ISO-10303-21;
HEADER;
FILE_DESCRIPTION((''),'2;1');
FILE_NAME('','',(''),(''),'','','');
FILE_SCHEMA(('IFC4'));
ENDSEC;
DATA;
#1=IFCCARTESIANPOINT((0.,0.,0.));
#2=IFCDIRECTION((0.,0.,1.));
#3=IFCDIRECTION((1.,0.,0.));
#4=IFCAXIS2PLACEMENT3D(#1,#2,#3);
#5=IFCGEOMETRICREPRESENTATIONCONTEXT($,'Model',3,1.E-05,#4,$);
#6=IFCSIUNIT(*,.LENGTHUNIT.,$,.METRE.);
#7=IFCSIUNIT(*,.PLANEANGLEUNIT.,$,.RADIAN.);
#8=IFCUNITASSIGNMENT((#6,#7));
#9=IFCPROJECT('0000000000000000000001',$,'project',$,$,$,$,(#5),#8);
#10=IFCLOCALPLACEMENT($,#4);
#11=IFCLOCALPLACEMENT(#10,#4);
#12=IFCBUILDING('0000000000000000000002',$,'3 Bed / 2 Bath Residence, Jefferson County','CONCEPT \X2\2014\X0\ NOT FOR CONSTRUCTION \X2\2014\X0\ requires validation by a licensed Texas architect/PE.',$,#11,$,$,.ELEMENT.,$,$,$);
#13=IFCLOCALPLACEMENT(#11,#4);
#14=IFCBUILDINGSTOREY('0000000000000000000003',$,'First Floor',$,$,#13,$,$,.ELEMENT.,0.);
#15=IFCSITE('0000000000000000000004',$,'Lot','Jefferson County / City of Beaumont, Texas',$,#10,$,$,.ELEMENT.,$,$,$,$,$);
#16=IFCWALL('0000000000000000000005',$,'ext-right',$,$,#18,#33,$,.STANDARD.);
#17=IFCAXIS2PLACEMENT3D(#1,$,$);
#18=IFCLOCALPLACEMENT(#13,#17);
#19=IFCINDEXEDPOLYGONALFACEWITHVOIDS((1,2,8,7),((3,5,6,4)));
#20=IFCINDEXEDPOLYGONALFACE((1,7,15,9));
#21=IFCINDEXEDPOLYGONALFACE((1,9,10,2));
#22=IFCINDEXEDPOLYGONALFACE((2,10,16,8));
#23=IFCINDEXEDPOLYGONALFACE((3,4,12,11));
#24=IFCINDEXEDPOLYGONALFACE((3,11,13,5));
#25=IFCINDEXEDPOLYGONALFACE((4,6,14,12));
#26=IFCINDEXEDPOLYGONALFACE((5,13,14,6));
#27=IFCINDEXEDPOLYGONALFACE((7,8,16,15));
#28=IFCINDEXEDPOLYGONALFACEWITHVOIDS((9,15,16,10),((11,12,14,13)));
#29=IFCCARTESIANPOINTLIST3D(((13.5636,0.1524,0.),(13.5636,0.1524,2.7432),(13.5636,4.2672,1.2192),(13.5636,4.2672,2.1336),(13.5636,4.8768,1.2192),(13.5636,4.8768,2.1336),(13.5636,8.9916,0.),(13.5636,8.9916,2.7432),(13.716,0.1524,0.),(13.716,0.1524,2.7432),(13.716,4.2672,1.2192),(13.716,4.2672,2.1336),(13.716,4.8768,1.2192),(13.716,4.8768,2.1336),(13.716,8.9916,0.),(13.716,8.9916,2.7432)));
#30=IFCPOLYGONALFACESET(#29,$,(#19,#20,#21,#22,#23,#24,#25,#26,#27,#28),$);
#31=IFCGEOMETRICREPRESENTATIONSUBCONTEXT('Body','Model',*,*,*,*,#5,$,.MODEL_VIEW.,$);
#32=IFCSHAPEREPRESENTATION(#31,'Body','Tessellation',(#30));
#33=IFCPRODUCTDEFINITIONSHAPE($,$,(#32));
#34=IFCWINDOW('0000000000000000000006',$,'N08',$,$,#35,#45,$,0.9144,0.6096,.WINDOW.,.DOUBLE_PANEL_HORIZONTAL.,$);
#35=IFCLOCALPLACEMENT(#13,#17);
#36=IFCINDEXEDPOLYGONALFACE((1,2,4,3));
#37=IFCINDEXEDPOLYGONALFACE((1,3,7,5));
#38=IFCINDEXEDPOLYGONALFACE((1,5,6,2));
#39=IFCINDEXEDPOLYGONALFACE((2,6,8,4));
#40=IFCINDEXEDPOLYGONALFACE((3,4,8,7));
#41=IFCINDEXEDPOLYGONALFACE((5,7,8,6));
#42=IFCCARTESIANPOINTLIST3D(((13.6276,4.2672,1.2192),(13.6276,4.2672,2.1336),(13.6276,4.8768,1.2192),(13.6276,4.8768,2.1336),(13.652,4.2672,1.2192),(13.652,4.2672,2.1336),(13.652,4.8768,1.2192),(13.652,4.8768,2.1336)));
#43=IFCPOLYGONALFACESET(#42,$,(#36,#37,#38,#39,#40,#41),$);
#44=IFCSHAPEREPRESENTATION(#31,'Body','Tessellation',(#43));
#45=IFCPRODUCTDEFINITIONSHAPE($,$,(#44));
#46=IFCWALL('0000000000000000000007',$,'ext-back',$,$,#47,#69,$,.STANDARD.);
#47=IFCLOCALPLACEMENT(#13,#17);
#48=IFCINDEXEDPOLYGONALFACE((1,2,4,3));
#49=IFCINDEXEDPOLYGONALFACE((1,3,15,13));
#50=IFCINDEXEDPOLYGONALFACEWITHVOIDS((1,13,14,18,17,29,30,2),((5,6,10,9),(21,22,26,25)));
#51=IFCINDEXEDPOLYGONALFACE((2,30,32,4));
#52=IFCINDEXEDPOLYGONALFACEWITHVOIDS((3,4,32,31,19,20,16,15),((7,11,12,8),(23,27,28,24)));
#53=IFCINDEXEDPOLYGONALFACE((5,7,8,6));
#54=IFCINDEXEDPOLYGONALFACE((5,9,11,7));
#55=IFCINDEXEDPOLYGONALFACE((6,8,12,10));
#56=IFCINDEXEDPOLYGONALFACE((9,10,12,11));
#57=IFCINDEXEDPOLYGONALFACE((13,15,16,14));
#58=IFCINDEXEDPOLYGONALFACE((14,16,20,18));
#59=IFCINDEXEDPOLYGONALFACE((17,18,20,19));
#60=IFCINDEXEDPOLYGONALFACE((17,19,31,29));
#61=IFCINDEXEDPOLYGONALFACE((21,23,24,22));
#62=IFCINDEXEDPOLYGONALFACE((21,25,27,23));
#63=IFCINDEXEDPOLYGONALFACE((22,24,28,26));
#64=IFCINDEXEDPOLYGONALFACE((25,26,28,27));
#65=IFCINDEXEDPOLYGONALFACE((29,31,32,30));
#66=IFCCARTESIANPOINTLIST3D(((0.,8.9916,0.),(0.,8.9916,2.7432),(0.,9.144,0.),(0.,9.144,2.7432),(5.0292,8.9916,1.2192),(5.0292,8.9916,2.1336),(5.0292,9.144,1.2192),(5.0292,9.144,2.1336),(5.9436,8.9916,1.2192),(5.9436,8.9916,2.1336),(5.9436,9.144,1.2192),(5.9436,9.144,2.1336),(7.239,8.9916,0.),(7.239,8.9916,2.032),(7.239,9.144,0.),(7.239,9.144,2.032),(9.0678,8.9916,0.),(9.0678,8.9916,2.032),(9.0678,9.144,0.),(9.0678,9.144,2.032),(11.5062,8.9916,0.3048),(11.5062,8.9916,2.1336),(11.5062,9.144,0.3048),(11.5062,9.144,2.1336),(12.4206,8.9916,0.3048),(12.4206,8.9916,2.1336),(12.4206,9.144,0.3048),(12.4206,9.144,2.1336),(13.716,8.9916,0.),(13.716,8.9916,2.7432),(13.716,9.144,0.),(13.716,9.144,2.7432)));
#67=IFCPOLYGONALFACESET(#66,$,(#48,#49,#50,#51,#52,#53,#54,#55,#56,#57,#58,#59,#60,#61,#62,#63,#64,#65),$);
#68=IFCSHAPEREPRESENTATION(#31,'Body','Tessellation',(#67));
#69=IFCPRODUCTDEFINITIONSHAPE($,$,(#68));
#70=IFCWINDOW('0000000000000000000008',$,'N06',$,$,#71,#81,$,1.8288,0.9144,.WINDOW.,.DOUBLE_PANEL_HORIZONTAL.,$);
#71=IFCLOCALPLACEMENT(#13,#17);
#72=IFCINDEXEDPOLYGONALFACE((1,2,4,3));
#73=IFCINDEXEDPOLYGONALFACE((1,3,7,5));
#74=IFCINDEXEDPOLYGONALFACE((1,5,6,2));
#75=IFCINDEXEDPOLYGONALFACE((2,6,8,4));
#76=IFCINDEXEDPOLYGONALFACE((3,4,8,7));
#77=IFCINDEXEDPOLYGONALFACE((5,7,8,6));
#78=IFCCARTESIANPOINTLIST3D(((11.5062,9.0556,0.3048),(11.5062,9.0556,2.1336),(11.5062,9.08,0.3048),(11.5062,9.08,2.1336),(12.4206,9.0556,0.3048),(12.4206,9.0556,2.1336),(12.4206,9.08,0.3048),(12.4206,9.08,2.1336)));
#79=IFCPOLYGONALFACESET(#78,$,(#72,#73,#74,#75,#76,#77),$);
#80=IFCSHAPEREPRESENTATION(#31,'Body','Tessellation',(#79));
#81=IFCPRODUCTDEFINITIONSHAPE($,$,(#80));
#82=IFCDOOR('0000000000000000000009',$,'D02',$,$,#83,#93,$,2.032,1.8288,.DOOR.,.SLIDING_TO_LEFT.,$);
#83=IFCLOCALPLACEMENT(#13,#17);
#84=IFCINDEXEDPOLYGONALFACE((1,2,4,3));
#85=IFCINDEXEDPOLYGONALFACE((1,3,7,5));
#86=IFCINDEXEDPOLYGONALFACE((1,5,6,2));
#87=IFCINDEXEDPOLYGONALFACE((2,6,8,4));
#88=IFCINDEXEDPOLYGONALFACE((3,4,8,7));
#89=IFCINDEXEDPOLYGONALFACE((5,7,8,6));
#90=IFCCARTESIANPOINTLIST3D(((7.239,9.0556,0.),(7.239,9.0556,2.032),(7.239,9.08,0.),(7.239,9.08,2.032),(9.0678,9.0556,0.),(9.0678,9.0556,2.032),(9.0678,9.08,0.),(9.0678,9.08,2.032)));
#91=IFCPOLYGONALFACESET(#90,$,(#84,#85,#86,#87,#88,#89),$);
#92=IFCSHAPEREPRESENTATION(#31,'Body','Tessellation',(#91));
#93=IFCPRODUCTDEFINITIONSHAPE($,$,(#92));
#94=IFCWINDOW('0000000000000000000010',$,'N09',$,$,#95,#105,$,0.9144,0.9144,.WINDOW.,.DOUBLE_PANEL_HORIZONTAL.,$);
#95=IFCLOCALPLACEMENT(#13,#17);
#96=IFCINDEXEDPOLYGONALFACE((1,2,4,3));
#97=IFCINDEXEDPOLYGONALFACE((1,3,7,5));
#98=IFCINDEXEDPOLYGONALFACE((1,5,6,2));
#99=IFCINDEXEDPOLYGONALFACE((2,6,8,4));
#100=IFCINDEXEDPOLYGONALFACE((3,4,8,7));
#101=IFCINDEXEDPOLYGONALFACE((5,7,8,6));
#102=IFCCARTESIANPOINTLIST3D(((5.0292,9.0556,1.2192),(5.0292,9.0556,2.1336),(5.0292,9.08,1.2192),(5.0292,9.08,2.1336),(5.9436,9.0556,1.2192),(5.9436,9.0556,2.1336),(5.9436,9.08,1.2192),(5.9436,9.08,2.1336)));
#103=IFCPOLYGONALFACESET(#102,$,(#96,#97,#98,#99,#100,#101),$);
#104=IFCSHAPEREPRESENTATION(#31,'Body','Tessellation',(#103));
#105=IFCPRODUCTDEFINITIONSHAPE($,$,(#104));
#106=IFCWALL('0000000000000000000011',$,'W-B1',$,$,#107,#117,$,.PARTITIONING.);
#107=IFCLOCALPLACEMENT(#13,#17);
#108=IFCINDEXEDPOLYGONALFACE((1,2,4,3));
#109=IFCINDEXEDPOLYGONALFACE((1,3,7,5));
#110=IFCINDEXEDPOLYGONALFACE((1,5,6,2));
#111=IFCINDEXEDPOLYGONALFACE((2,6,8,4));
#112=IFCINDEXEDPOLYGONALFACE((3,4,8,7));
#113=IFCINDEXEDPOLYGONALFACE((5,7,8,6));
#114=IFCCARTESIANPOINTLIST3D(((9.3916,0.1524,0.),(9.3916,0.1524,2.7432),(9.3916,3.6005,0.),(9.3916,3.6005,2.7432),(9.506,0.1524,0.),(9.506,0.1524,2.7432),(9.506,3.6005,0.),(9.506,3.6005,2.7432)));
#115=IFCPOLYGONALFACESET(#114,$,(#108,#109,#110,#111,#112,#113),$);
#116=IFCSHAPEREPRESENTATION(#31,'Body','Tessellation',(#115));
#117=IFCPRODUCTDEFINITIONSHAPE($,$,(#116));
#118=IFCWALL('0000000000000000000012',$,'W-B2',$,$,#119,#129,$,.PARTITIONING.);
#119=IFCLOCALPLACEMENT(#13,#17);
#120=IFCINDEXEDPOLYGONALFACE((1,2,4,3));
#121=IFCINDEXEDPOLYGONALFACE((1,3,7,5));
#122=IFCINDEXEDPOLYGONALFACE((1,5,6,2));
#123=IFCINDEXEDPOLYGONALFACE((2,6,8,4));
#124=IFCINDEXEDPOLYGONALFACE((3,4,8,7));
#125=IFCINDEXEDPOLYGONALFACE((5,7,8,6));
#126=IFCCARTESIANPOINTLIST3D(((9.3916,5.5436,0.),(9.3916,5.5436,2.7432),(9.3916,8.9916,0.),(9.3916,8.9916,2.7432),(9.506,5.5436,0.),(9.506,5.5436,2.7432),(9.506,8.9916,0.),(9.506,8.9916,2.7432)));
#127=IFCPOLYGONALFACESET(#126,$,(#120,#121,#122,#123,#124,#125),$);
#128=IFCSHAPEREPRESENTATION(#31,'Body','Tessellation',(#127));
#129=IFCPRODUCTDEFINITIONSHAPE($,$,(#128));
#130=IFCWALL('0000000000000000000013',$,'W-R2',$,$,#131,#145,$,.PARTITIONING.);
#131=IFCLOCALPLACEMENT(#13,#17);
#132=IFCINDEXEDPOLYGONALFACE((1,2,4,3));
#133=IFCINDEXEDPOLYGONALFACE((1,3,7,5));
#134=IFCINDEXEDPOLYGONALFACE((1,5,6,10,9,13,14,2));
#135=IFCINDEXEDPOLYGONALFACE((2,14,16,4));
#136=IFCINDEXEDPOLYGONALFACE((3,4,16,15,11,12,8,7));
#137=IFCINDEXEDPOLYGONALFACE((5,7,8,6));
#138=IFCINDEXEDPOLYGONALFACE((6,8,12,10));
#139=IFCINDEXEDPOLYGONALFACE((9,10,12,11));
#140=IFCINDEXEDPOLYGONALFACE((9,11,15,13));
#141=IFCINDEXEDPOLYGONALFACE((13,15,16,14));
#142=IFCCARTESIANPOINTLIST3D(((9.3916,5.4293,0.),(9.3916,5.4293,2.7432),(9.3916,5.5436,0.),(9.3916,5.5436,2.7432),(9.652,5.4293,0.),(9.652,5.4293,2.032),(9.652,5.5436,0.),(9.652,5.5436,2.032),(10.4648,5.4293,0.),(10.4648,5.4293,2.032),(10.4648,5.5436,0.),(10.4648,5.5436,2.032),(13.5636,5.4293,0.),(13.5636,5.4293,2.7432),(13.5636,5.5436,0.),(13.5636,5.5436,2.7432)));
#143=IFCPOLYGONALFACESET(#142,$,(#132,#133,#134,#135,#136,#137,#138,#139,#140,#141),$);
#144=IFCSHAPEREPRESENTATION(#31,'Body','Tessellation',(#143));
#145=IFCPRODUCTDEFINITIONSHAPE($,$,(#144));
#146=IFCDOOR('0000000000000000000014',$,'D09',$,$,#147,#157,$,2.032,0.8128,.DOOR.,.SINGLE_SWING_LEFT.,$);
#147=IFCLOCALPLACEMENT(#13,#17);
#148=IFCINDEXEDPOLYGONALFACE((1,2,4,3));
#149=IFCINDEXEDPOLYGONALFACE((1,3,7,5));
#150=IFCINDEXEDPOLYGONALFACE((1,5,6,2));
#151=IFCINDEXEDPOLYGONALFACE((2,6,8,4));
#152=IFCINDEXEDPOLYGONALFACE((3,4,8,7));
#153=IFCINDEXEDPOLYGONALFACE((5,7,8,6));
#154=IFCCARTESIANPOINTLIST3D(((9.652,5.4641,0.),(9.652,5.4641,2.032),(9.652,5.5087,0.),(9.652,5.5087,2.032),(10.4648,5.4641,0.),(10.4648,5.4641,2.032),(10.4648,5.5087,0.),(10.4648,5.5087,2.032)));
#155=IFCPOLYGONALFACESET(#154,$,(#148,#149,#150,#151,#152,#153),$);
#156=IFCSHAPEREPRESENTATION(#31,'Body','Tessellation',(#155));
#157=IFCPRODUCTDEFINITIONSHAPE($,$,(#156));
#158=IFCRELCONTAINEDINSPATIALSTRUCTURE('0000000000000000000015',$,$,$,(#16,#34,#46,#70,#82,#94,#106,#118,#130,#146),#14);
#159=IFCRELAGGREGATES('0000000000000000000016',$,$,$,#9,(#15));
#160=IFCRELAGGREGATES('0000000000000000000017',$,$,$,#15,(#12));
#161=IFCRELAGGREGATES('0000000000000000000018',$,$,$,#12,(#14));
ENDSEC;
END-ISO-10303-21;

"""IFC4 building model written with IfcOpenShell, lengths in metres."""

from ifc_helpers import new_model, si_unit, frame, frame_2d, origin_with_axes, place, context, subcontext, project, spatial, rectangle, extrude, element, fill, save


model = new_model("IFC4")

# Units and contexts
model_context = context("Model", 3, precision=1e-05, world=origin_with_axes())
body_context = subcontext(model_context, "Body", "Model", "MODEL_VIEW")
ifc_project = project(units=[si_unit("LENGTHUNIT", "METRE"), si_unit("PLANEANGLEUNIT", "RADIAN")], contexts=[model_context])

# Site, building, storey
site_placement = place(None, origin_with_axes())
site = spatial("IfcSite", under=ifc_project, at=site_placement, Name="Lot", Description="Jefferson County / City of Beaumont, Texas", CompositionType="ELEMENT")
building_placement = place(site_placement, origin_with_axes())
building = spatial("IfcBuilding", under=site, at=building_placement, Name="3 Bed / 2 Bath Residence, Jefferson County", Description="CONCEPT — NOT FOR CONSTRUCTION — requires validation by a licensed Texas architect/PE.", CompositionType="ELEMENT")
storey_placement = place(building_placement, origin_with_axes())
storey = spatial("IfcBuildingStorey", under=building, at=storey_placement, Name="First Floor", CompositionType="ELEMENT", Elevation=0.0)

# Wall, opening, window
wall_1_placement = place(storey_placement, frame((13.6398, 0.1524, 0.0), z_axis=(0.0, 0.0, 1.0), x_axis=(0.0, 1.0, 0.0)))
wall_1 = element("IfcWall", 1, at=wall_1_placement, inside=storey, Name="ext-right", PredefinedType="STANDARD", context=body_context, shape_type="SweptSolid", body=[
    extrude(rectangle(XDim=8.8392, YDim=0.1524, at=frame_2d((4.4196, 0.0), x_axis=(1.0, 0.0))), origin_with_axes(), (0.0, 0.0, 1.0), 2.7432),
])
opening_1_placement = place(wall_1_placement, frame((4.1148, 0.0, 1.2192), z_axis=(0.0, 0.0, 1.0), x_axis=(1.0, 0.0, 0.0)))
opening_1 = element("IfcOpeningElement", 2, at=opening_1_placement, cuts=wall_1, PredefinedType="OPENING", context=body_context, shape_type="SweptSolid", body=[
    extrude(rectangle(XDim=0.6096, YDim=0.1829, at=frame_2d((0.3048, 0.0), x_axis=(1.0, 0.0))), origin_with_axes(), (0.0, 0.0, 1.0), 0.9144),
])
window_1_placement = place(opening_1_placement, origin_with_axes())
window_1 = element("IfcWindow", 3, at=window_1_placement, inside=storey, Name="N08", OverallHeight=0.9144, OverallWidth=0.6096, PartitioningType="DOUBLE_PANEL_HORIZONTAL", PredefinedType="WINDOW", context=body_context, shape_type="SweptSolid", body=[
    extrude(rectangle(XDim=0.6096, YDim=0.0244, at=frame_2d((0.3048, 0.0), x_axis=(1.0, 0.0))), origin_with_axes(), (0.0, 0.0, 1.0), 0.9144),
])
fill(opening_1, window_1)

# Wall, openings, windows, door
wall_2_placement = place(storey_placement, frame((13.716, 9.0678, 0.0), z_axis=(0.0, 0.0, 1.0), x_axis=(-1.0, 0.0, 0.0)))
wall_2 = element("IfcWall", 4, at=wall_2_placement, inside=storey, Name="ext-back", PredefinedType="STANDARD", context=body_context, shape_type="SweptSolid", body=[
    extrude(rectangle(XDim=13.716, YDim=0.1524, at=frame_2d((6.858, 0.0), x_axis=(1.0, 0.0))), origin_with_axes(), (0.0, 0.0, 1.0), 2.7432),
])
opening_2_placement = place(wall_2_placement, frame((1.2954, 0.0, 0.3048), z_axis=(0.0, 0.0, 1.0), x_axis=(1.0, 0.0, 0.0)))
opening_2 = element("IfcOpeningElement", 5, at=opening_2_placement, cuts=wall_2, PredefinedType="OPENING", context=body_context, shape_type="SweptSolid", body=[
    extrude(rectangle(XDim=0.9144, YDim=0.1829, at=frame_2d((0.4572, 0.0), x_axis=(1.0, 0.0))), origin_with_axes(), (0.0, 0.0, 1.0), 1.8288),
])
opening_3_placement = place(wall_2_placement, frame((4.6482, 0.0, 0.0), z_axis=(0.0, 0.0, 1.0), x_axis=(1.0, 0.0, 0.0)))
opening_3 = element("IfcOpeningElement", 6, at=opening_3_placement, cuts=wall_2, PredefinedType="OPENING", context=body_context, shape_type="SweptSolid", body=[
    extrude(rectangle(XDim=1.8288, YDim=0.1829, at=frame_2d((0.9144, 0.0), x_axis=(1.0, 0.0))), origin_with_axes(), (0.0, 0.0, 1.0), 2.032),
])
opening_4_placement = place(wall_2_placement, frame((7.7724, 0.0, 1.2192), z_axis=(0.0, 0.0, 1.0), x_axis=(1.0, 0.0, 0.0)))
opening_4 = element("IfcOpeningElement", 7, at=opening_4_placement, cuts=wall_2, PredefinedType="OPENING", context=body_context, shape_type="SweptSolid", body=[
    extrude(rectangle(XDim=0.9144, YDim=0.1829, at=frame_2d((0.4572, 0.0), x_axis=(1.0, 0.0))), origin_with_axes(), (0.0, 0.0, 1.0), 0.9144),
])
window_2_placement = place(opening_2_placement, origin_with_axes())
window_2 = element("IfcWindow", 8, at=window_2_placement, inside=storey, Name="N06", OverallHeight=1.8288, OverallWidth=0.9144, PartitioningType="DOUBLE_PANEL_HORIZONTAL", PredefinedType="WINDOW", context=body_context, shape_type="SweptSolid", body=[
    extrude(rectangle(XDim=0.9144, YDim=0.0244, at=frame_2d((0.4572, 0.0), x_axis=(1.0, 0.0))), origin_with_axes(), (0.0, 0.0, 1.0), 1.8288),
])
fill(opening_2, window_2)
door_1_placement = place(opening_3_placement, origin_with_axes())
door_1 = element("IfcDoor", 9, at=door_1_placement, inside=storey, Name="D02", OperationType="SLIDING_TO_LEFT", OverallHeight=2.032, OverallWidth=1.8288, PredefinedType="DOOR", context=body_context, shape_type="SweptSolid", body=[
    extrude(rectangle(XDim=1.8288, YDim=0.0244, at=frame_2d((0.9144, 0.0), x_axis=(1.0, 0.0))), origin_with_axes(), (0.0, 0.0, 1.0), 2.032),
])
fill(opening_3, door_1)
window_3_placement = place(opening_4_placement, origin_with_axes())
window_3 = element("IfcWindow", 10, at=window_3_placement, inside=storey, Name="N09", OverallHeight=0.9144, OverallWidth=0.9144, PartitioningType="DOUBLE_PANEL_HORIZONTAL", PredefinedType="WINDOW", context=body_context, shape_type="SweptSolid", body=[
    extrude(rectangle(XDim=0.9144, YDim=0.0244, at=frame_2d((0.4572, 0.0), x_axis=(1.0, 0.0))), origin_with_axes(), (0.0, 0.0, 1.0), 0.9144),
])
fill(opening_4, window_3)

# Walls
for number, where, z_axis, x_axis, name in (
    (11, (9.4488, 0.1524, 0.0), (0.0, 0.0, 1.0), (0.0, 1.0, 0.0), "W-B1"),
    (12, (9.4488, 5.5436, 0.0), (0.0, 0.0, 1.0), (0.0, 1.0, 0.0), "W-B2"),
):
    element("IfcWall", number, at=place(storey_placement, frame(where, z_axis=z_axis, x_axis=x_axis)), inside=storey, Name=name, PredefinedType="PARTITIONING", context=body_context, shape_type="SweptSolid", body=[
        extrude(rectangle(XDim=3.4481, YDim=0.1143, at=frame_2d((1.724, 0.0), x_axis=(1.0, 0.0))), origin_with_axes(), (0.0, 0.0, 1.0), 2.7432),
    ])

# Wall, opening, door
wall_3_placement = place(storey_placement, frame((9.3917, 5.4864, 0.0), z_axis=(0.0, 0.0, 1.0), x_axis=(1.0, 0.0, 0.0)))
wall_3 = element("IfcWall", 13, at=wall_3_placement, inside=storey, Name="W-R2", PredefinedType="PARTITIONING", context=body_context, shape_type="SweptSolid", body=[
    extrude(rectangle(XDim=4.1719, YDim=0.1143, at=frame_2d((2.086, 0.0), x_axis=(1.0, 0.0))), origin_with_axes(), (0.0, 0.0, 1.0), 2.7432),
])
opening_5_placement = place(wall_3_placement, frame((0.2603, 0.0, 0.0), z_axis=(0.0, 0.0, 1.0), x_axis=(1.0, 0.0, 0.0)))
opening_5 = element("IfcOpeningElement", 14, at=opening_5_placement, cuts=wall_3, PredefinedType="OPENING", context=body_context, shape_type="SweptSolid", body=[
    extrude(rectangle(XDim=0.8128, YDim=0.1448, at=frame_2d((0.4064, 0.0), x_axis=(1.0, 0.0))), origin_with_axes(), (0.0, 0.0, 1.0), 2.032),
])
door_2_placement = place(opening_5_placement, origin_with_axes())
door_2 = element("IfcDoor", 15, at=door_2_placement, inside=storey, Name="D09", OperationType="SINGLE_SWING_LEFT", OverallHeight=2.032, OverallWidth=0.8128, PredefinedType="DOOR", context=body_context, shape_type="SweptSolid", body=[
    extrude(rectangle(XDim=0.8128, YDim=0.0445, at=frame_2d((0.4064, 0.0), x_axis=(1.0, 0.0))), origin_with_axes(), (0.0, 0.0, 1.0), 2.032),
])
fill(opening_5, door_2)

save(model, "model.ifc")
